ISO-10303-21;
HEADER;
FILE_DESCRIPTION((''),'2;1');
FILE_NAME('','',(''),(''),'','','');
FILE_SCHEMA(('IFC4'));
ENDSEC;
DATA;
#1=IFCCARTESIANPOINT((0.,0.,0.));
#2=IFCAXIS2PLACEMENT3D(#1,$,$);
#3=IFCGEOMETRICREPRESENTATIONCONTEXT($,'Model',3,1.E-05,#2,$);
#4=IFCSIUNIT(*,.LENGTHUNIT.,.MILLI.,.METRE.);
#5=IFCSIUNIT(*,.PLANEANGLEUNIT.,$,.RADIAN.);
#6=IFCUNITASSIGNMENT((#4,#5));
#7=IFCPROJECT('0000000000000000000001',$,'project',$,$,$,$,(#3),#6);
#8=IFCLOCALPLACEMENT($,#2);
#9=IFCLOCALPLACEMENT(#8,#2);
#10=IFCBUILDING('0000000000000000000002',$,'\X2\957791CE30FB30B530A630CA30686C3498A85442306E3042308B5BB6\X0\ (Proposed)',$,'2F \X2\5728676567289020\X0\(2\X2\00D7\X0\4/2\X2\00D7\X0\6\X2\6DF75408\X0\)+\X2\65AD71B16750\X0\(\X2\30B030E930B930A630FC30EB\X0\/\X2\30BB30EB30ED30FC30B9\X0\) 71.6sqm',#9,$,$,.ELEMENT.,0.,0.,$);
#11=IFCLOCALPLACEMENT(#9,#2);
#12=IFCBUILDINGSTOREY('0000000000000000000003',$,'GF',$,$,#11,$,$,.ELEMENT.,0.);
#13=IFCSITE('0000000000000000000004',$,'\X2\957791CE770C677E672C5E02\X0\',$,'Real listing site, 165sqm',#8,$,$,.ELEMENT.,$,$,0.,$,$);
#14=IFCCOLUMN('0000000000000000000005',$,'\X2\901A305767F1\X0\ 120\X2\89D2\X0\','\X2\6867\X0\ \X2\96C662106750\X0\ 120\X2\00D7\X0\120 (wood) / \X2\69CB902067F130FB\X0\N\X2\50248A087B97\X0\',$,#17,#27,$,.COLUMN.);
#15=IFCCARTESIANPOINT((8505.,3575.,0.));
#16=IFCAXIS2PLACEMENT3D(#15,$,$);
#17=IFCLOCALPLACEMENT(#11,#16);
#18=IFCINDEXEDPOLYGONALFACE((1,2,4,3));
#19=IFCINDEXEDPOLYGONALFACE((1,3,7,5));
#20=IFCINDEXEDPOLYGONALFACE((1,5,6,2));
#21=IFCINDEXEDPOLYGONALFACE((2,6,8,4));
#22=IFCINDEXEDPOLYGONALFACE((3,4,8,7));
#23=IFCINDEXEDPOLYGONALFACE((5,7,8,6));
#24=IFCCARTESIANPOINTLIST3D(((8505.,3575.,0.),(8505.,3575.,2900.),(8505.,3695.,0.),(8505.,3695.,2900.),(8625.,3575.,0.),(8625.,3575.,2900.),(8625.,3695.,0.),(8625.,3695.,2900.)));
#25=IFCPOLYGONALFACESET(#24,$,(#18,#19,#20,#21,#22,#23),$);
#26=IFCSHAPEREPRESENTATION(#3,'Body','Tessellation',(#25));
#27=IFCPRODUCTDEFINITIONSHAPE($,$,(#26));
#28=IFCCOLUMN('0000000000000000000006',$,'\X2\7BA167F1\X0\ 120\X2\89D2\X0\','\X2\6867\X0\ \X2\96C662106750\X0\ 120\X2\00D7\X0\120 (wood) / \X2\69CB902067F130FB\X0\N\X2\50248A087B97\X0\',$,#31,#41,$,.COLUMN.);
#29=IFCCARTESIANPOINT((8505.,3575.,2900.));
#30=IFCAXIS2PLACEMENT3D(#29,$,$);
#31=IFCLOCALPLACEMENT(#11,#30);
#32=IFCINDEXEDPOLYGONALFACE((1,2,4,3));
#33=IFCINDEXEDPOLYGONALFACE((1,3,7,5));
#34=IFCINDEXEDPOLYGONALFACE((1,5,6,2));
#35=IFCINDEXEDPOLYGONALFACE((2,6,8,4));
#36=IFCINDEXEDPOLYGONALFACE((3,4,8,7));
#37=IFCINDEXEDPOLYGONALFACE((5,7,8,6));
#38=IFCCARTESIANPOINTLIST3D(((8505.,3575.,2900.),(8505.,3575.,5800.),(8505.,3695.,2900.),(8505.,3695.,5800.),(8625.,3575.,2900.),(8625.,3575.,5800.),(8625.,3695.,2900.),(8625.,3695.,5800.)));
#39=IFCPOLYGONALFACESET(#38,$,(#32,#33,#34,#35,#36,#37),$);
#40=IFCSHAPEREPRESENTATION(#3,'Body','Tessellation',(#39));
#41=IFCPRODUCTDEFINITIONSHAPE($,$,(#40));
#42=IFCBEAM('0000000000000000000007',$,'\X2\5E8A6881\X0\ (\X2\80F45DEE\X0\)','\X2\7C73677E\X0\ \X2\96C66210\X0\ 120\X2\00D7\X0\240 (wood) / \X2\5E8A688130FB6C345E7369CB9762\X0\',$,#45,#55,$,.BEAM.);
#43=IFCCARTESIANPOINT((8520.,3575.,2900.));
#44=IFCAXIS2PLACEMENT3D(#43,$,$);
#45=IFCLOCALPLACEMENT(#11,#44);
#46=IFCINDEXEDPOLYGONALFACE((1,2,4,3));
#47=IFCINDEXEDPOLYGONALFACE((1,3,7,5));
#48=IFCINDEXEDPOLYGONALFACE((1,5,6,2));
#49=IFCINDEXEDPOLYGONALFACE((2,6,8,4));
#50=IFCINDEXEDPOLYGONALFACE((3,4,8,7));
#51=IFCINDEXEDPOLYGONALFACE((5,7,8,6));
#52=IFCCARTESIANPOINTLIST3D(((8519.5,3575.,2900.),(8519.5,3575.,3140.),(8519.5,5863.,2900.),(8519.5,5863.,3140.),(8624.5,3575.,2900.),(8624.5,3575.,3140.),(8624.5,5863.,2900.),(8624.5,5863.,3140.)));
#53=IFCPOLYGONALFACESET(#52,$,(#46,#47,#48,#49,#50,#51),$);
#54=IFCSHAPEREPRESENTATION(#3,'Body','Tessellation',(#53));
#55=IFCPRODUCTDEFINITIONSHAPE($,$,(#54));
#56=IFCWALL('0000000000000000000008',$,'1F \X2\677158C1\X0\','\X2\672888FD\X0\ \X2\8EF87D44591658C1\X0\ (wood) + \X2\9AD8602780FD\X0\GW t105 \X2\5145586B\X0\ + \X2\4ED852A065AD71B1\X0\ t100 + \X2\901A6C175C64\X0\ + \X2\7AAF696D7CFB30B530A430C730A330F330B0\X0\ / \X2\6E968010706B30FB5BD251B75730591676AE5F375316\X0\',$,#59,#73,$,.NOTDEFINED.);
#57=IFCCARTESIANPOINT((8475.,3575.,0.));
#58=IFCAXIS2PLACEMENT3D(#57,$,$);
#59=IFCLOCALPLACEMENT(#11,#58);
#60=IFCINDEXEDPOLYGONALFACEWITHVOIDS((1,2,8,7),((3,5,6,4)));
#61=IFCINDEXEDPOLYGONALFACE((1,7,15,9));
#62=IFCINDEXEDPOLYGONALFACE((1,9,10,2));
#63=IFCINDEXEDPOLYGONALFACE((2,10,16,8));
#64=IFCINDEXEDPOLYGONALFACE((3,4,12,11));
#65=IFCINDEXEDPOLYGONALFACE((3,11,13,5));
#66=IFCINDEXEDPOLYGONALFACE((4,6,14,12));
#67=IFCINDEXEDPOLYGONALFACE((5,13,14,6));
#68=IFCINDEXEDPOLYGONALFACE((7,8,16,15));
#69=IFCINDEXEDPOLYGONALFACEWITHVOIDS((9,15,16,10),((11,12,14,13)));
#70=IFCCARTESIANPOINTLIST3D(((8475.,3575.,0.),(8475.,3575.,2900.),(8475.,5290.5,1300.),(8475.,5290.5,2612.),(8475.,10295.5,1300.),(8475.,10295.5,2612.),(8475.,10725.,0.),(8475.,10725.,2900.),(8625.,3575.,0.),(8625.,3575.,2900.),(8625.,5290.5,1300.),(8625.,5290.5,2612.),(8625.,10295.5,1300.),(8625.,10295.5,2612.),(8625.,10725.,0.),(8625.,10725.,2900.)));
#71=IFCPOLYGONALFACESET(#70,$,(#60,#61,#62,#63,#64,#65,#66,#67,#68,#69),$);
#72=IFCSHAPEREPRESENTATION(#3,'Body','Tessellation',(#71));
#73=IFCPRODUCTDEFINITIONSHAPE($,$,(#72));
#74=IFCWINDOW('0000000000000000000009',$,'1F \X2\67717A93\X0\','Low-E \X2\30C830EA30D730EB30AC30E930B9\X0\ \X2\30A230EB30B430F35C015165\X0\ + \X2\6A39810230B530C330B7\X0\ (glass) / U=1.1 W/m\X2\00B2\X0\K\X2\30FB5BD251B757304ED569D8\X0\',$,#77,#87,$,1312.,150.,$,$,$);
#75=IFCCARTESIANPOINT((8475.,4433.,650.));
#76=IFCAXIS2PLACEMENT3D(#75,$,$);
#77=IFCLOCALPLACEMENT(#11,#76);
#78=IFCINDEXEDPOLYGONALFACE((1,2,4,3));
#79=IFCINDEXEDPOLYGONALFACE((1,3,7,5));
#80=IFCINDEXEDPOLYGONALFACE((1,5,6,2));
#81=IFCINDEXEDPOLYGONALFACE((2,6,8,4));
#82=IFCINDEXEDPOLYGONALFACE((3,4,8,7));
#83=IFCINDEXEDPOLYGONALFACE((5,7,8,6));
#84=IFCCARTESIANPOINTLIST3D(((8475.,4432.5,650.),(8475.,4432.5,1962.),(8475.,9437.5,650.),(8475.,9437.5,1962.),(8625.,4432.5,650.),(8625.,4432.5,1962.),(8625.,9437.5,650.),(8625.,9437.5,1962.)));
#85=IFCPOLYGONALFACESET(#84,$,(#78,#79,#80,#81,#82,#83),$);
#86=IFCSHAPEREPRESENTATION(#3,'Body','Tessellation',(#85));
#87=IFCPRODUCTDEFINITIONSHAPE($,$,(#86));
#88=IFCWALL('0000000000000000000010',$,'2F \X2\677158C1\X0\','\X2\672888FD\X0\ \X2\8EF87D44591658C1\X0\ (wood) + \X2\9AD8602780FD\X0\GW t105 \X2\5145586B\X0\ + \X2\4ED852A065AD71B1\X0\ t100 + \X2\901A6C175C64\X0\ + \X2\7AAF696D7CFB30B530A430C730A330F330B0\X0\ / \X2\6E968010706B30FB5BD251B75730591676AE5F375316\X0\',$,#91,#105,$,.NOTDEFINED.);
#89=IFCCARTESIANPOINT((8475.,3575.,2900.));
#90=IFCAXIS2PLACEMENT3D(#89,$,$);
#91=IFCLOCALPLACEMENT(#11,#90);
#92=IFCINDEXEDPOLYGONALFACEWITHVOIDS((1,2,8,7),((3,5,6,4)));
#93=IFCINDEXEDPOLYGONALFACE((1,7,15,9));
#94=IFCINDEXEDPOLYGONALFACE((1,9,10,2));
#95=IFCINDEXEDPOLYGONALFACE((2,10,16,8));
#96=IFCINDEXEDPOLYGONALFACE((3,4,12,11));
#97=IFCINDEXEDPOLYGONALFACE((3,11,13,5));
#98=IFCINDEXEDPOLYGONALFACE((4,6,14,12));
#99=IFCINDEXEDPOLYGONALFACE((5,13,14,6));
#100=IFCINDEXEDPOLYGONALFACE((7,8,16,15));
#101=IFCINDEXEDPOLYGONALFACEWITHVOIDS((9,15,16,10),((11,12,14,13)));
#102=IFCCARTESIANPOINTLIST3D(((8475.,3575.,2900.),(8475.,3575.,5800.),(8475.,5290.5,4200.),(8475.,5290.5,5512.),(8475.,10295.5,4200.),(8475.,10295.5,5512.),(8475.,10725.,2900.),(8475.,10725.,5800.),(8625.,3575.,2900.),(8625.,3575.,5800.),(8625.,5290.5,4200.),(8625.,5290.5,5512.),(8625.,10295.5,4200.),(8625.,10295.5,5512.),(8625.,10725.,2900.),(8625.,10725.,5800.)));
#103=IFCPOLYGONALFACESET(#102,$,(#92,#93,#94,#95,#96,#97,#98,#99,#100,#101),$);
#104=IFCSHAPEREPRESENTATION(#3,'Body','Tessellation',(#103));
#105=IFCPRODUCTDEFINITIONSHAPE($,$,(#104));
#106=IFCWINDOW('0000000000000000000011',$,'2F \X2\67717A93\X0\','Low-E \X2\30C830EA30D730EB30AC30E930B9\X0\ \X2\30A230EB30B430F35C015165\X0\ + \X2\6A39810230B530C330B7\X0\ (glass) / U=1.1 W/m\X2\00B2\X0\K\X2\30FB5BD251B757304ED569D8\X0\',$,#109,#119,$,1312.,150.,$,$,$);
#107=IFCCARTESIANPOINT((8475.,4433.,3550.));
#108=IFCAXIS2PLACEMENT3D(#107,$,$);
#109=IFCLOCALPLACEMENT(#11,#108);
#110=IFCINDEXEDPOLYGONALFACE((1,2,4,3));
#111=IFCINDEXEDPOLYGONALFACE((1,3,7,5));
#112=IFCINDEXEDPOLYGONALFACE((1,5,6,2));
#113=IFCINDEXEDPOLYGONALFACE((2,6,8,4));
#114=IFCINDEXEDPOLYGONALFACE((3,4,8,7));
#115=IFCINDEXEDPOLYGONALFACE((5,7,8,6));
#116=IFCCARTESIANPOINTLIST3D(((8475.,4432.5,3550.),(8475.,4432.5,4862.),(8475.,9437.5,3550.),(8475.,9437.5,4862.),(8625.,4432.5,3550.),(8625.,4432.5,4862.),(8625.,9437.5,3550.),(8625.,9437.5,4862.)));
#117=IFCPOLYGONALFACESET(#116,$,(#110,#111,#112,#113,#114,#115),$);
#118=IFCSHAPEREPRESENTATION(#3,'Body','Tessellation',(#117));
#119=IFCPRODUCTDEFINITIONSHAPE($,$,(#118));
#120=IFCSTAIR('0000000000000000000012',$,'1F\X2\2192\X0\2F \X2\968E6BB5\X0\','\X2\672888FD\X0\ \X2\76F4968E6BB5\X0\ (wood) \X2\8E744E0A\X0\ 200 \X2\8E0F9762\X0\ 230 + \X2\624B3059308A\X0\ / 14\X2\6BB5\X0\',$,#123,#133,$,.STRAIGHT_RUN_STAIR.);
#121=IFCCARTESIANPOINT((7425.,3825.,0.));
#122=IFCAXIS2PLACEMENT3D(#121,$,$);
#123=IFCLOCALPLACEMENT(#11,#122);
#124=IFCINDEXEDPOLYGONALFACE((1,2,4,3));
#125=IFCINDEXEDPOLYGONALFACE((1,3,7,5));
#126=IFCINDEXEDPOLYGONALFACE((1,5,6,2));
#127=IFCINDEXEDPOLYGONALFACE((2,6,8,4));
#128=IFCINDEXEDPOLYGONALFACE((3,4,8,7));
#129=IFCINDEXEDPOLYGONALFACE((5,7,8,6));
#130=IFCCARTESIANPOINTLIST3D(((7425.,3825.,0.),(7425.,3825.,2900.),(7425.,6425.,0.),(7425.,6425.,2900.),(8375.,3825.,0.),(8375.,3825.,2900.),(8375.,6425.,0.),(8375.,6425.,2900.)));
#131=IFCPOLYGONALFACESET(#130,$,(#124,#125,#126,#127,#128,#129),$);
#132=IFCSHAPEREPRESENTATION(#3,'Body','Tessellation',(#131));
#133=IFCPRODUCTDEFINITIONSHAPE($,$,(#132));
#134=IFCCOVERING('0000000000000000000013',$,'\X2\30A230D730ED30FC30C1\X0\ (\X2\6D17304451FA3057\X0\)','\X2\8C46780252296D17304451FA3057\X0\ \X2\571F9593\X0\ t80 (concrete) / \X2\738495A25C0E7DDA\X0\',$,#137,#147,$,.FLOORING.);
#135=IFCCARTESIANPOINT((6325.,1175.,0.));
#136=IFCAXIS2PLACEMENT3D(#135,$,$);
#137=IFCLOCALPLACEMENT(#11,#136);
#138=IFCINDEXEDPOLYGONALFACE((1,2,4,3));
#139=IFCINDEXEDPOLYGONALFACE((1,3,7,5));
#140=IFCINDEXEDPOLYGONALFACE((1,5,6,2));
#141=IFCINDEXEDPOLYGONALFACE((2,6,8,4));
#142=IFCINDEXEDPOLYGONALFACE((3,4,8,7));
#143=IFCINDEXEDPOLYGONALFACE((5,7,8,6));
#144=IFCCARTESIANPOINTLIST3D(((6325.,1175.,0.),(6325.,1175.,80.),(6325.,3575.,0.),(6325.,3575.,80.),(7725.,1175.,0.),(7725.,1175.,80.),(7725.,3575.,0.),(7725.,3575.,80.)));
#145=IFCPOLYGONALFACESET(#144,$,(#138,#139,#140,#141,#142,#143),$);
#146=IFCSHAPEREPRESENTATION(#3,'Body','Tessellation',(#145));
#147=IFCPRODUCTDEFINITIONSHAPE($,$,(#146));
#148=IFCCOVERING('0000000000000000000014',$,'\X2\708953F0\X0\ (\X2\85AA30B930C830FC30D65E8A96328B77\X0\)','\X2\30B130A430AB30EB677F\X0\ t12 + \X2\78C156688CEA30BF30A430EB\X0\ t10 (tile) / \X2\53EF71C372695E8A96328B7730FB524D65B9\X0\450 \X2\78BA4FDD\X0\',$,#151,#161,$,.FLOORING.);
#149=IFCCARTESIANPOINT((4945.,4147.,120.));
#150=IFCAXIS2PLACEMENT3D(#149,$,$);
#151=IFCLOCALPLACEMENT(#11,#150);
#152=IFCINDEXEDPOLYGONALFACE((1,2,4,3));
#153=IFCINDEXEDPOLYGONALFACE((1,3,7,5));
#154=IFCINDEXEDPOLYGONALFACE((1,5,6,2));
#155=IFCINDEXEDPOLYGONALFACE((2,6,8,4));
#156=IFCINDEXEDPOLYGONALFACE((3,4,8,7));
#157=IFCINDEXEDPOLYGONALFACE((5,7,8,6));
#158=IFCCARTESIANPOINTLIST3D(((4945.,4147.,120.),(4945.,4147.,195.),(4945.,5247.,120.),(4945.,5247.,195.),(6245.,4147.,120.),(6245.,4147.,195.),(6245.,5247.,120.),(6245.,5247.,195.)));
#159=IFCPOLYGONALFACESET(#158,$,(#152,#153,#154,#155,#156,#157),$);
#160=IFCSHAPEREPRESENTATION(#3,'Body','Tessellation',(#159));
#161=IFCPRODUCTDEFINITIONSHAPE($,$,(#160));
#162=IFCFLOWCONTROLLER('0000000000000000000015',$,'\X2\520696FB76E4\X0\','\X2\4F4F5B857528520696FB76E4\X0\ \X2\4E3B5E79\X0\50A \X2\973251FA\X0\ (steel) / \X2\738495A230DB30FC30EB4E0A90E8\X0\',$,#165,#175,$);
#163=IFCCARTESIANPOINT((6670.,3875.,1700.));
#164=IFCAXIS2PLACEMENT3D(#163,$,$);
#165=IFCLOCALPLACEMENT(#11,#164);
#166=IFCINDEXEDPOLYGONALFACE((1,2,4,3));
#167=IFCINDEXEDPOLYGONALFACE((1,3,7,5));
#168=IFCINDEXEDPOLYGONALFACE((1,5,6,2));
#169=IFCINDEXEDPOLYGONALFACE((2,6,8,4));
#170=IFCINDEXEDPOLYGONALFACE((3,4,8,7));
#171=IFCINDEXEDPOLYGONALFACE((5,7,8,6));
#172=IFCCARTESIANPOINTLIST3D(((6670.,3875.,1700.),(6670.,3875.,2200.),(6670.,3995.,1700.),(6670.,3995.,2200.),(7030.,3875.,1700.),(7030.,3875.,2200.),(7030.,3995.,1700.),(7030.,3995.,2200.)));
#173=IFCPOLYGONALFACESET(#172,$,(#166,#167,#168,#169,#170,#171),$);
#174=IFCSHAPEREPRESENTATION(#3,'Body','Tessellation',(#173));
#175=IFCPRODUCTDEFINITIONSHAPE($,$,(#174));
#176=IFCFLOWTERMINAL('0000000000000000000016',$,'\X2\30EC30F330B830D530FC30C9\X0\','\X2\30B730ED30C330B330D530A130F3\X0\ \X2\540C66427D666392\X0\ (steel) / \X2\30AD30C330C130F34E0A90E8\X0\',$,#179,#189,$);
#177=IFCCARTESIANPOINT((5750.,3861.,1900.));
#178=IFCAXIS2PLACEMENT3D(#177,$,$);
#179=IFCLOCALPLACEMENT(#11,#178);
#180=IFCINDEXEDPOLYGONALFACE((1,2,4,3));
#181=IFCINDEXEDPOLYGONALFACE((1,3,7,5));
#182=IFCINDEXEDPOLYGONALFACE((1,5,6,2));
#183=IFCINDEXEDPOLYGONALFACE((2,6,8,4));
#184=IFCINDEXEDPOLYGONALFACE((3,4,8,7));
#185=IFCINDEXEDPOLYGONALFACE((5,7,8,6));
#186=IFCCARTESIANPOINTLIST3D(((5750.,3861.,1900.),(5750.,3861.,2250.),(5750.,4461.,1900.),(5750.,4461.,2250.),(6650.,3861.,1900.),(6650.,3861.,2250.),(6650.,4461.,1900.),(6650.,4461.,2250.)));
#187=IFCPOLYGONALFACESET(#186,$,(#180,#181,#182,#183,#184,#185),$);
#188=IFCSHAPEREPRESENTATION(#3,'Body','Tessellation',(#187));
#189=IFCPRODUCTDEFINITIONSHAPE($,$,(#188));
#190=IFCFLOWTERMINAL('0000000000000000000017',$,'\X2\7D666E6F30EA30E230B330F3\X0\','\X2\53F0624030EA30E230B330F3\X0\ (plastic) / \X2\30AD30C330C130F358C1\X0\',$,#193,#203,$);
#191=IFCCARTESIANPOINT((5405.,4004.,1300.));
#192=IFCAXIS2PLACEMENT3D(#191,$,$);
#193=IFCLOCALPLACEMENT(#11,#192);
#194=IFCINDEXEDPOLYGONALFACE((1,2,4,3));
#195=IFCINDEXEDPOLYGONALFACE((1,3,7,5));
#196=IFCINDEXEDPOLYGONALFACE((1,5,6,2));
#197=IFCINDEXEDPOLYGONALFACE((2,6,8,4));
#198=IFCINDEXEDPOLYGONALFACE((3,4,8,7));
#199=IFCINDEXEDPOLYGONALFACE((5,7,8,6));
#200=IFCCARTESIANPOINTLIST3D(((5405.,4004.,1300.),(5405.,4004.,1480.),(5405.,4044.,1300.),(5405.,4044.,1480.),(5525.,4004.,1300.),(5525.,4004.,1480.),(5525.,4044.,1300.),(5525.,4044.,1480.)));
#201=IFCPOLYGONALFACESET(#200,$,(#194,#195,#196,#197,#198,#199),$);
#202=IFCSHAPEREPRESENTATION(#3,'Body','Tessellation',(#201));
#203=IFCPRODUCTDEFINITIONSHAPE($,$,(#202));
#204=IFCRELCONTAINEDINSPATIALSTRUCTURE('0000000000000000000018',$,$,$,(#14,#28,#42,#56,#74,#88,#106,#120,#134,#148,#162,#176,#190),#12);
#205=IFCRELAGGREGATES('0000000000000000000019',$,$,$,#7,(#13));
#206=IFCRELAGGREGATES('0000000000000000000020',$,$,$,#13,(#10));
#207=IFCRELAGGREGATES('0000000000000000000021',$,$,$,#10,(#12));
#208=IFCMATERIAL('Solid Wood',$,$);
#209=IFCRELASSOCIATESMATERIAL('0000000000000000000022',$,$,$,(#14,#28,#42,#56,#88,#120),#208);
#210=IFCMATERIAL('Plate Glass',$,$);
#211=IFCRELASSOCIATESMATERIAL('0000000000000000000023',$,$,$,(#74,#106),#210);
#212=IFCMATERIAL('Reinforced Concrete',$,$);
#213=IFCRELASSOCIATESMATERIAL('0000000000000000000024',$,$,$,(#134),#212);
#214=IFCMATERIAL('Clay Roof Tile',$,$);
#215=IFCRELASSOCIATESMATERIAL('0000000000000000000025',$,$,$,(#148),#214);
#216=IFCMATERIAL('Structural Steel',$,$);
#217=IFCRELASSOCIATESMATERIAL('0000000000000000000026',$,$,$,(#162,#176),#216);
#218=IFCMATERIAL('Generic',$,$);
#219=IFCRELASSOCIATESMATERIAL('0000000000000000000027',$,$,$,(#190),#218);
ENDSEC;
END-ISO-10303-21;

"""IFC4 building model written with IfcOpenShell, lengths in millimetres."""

from ifc_helpers import new_model, si_unit, frame, frame_2d, origin, place, context, project, spatial, rectangle, extrude, material, element, fill, save


model = new_model("IFC4")

# Units and contexts
model_context = context("Model", 3, precision=1e-05, world=origin())
ifc_project = project(units=[si_unit("LENGTHUNIT", "METRE", prefix="MILLI"), si_unit("PLANEANGLEUNIT", "RADIAN")], contexts=[model_context])

# Site, building, storey
site_placement = place(None, origin())
site = spatial("IfcSite", under=ifc_project, at=site_placement, Name="長野県松本市", ObjectType="Real listing site, 165sqm", CompositionType="ELEMENT", RefElevation=0.0)
building_placement = place(site_placement, origin())
building = spatial("IfcBuilding", under=site, at=building_placement, Name="長野・サウナと水風呂のある家 (Proposed)", ObjectType="2F 在来木造(2×4/2×6混合)+断熱材(グラスウール/セルロース) 71.6sqm", CompositionType="ELEMENT", ElevationOfRefHeight=0.0, ElevationOfTerrain=0.0)
storey_placement = place(building_placement, origin())
storey = spatial("IfcBuildingStorey", under=building, at=storey_placement, Name="GF", CompositionType="ELEMENT", Elevation=0.0)

# Columns
ifc_material_1 = material(Name="Solid Wood")
column_1_placement = place(storey_placement, frame((8505.0, 3575.0, 0.0)))
element("IfcColumn", 1, at=column_1_placement, inside=storey, material=ifc_material_1, Name="通し柱 120角", Description="桧 集成材 120×120 (wood) / 構造柱・N値計算", PredefinedType="COLUMN", context=model_context, shape_type="SweptSolid", body=[
    extrude(rectangle(XDim=120.0, YDim=120.0, at=frame_2d((60.0, 60.0))), frame((8505.0, 3575.0, 0.0)), (0.0, 0.0, 1.0), 2900.0),
])
column_2_placement = place(storey_placement, frame((8505.0, 3575.0, 2900.0)))
element("IfcColumn", 2, at=column_2_placement, inside=storey, material=ifc_material_1, Name="管柱 120角", Description="桧 集成材 120×120 (wood) / 構造柱・N値計算", PredefinedType="COLUMN", context=model_context, shape_type="SweptSolid", body=[
    extrude(rectangle(XDim=120.0, YDim=120.0, at=frame_2d((60.0, 60.0))), frame((8505.0, 3575.0, 2900.0)), (0.0, 0.0, 1.0), 2900.0),
])

# Beam
beam_1_placement = place(storey_placement, frame((8520.0, 3575.0, 2900.0)))
element("IfcBeam", 3, at=beam_1_placement, inside=storey, material=ifc_material_1, Name="床梁 (胴差)", Description="米松 集成 120×240 (wood) / 床梁・水平構面", PredefinedType="BEAM", context=model_context, shape_type="SweptSolid", body=[
    extrude(rectangle(XDim=105.0, YDim=2288.0, at=frame_2d((52.0, 1144.0))), frame((8520.0, 3575.0, 2900.0)), (0.0, 0.0, 1.0), 240.0),
])

# Wall, opening, window
wall_1_placement = place(storey_placement, frame((8475.0, 3575.0, 0.0)))
wall_1 = element("IfcWall", 4, at=wall_1_placement, inside=storey, material=ifc_material_1, Name="1F 東壁", Description="木製 軸組外壁 (wood) + 高性能GW t105 充填 + 付加断熱 t100 + 通気層 + 窯業系サイディング / 準耐火・寒冷地外皮強化", PredefinedType="NOTDEFINED", context=model_context, shape_type="SweptSolid", body=[
    extrude(rectangle(XDim=150.0, YDim=7150.0, at=frame_2d((75.0, 3575.0))), frame((8475.0, 3575.0, 0.0)), (0.0, 0.0, 1.0), 2900.0),
])
opening_1_placement = place(storey_placement, frame((8475.0, 4433.0, 650.0)))
opening_1 = element("IfcOpeningElement", 5, at=opening_1_placement, cuts=wall_1, PredefinedType="NOTDEFINED", context=model_context, shape_type="SweptSolid", body=[
    extrude(rectangle(XDim=150.0, YDim=5005.0, at=frame_2d((75.0, 2502.0))), frame((8475.0, 4433.0, 650.0)), (0.0, 0.0, 1.0), 1312.0),
])
ifc_material_2 = material(Name="Plate Glass")
window_1_placement = place(storey_placement, frame((8475.0, 4433.0, 650.0)))
window_1 = element("IfcWindow", 6, at=window_1_placement, inside=storey, material=ifc_material_2, Name="1F 東窓", Description="Low-E トリプルガラス アルゴン封入 + 樹脂サッシ (glass) / U=1.1 W/m²K・寒冷地仕様", OverallHeight=1312.0, OverallWidth=150.0, context=model_context, shape_type="SweptSolid", body=[
    extrude(rectangle(XDim=150.0, YDim=5005.0, at=frame_2d((75.0, 2502.0))), frame((8475.0, 4433.0, 650.0)), (0.0, 0.0, 1.0), 1312.0),
])
fill(opening_1, window_1)

# Wall, opening, window
wall_2_placement = place(storey_placement, frame((8475.0, 3575.0, 2900.0)))
wall_2 = element("IfcWall", 7, at=wall_2_placement, inside=storey, material=ifc_material_1, Name="2F 東壁", Description="木製 軸組外壁 (wood) + 高性能GW t105 充填 + 付加断熱 t100 + 通気層 + 窯業系サイディング / 準耐火・寒冷地外皮強化", PredefinedType="NOTDEFINED", context=model_context, shape_type="SweptSolid", body=[
    extrude(rectangle(XDim=150.0, YDim=7150.0, at=frame_2d((75.0, 3575.0))), frame((8475.0, 3575.0, 2900.0)), (0.0, 0.0, 1.0), 2900.0),
])
opening_2_placement = place(storey_placement, frame((8475.0, 4433.0, 3550.0)))
opening_2 = element("IfcOpeningElement", 8, at=opening_2_placement, cuts=wall_2, PredefinedType="NOTDEFINED", context=model_context, shape_type="SweptSolid", body=[
    extrude(rectangle(XDim=150.0, YDim=5005.0, at=frame_2d((75.0, 2502.0))), frame((8475.0, 4433.0, 3550.0)), (0.0, 0.0, 1.0), 1312.0),
])
window_2_placement = place(storey_placement, frame((8475.0, 4433.0, 3550.0)))
window_2 = element("IfcWindow", 9, at=window_2_placement, inside=storey, material=ifc_material_2, Name="2F 東窓", Description="Low-E トリプルガラス アルゴン封入 + 樹脂サッシ (glass) / U=1.1 W/m²K・寒冷地仕様", OverallHeight=1312.0, OverallWidth=150.0, context=model_context, shape_type="SweptSolid", body=[
    extrude(rectangle(XDim=150.0, YDim=5005.0, at=frame_2d((75.0, 2502.0))), frame((8475.0, 4433.0, 3550.0)), (0.0, 0.0, 1.0), 1312.0),
])
fill(opening_2, window_2)

# Stair
stair_placement = place(storey_placement, frame((7425.0, 3825.0, 0.0)))
element("IfcStair", 10, at=stair_placement, inside=storey, material=ifc_material_1, Name="1F→2F 階段", Description="木製 直階段 (wood) 蹴上 200 踏面 230 + 手すり / 14段", PredefinedType="STRAIGHT_RUN_STAIR", context=model_context, shape_type="SweptSolid", body=[
    extrude(rectangle(XDim=950.0, YDim=2600.0, at=frame_2d((475.0, 1300.0))), frame((7425.0, 3825.0, 0.0)), (0.0, 0.0, 1.0), 2900.0),
])

# Coverings
ifc_material_3 = material(Name="Reinforced Concrete")
covering_1_placement = place(storey_placement, frame((6325.0, 1175.0, 0.0)))
element("IfcCovering", 11, at=covering_1_placement, inside=storey, material=ifc_material_3, Name="アプローチ (洗い出し)", Description="豆砂利洗い出し 土間 t80 (concrete) / 玄関導線", PredefinedType="FLOORING", context=model_context, shape_type="SweptSolid", body=[
    extrude(rectangle(XDim=1400.0, YDim=2400.0, at=frame_2d((700.0, 1200.0))), frame((6325.0, 1175.0, 0.0)), (0.0, 0.0, 1.0), 80.0),
])
ifc_material_4 = material(Name="Clay Roof Tile")
covering_2_placement = place(storey_placement, frame((4945.0, 4147.0, 120.0)))
element("IfcCovering", 12, at=covering_2_placement, inside=storey, material=ifc_material_4, Name="炉台 (薪ストーブ床防護)", Description="ケイカル板 t12 + 磁器質タイル t10 (tile) / 可燃物床防護・前方450 確保", PredefinedType="FLOORING", context=model_context, shape_type="SweptSolid", body=[
    extrude(rectangle(XDim=1300.0, YDim=1100.0, at=frame_2d((650.0, 550.0))), frame((4945.0, 4147.0, 120.0)), (0.0, 0.0, 1.0), 75.0),
])

# Flow controller
ifc_material_5 = material(Name="Structural Steel")
flow_controller_placement = place(storey_placement, frame((6670.0, 3875.0, 1700.0)))
element("IfcFlowController", 13, at=flow_controller_placement, inside=storey, material=ifc_material_5, Name="分電盤", Description="住宅用分電盤 主幹50A 露出 (steel) / 玄関ホール上部", context=model_context, shape_type="SweptSolid", body=[
    extrude(rectangle(XDim=360.0, YDim=120.0, at=frame_2d((180.0, 60.0))), frame((6670.0, 3875.0, 1700.0)), (0.0, 0.0, 1.0), 500.0),
])

# Flow terminals
flow_terminal_1_placement = place(storey_placement, frame((5750.0, 3861.0, 1900.0)))
element("IfcFlowTerminal", 14, at=flow_terminal_1_placement, inside=storey, material=ifc_material_5, Name="レンジフード", Description="シロッコファン 同時給排 (steel) / キッチン上部", context=model_context, shape_type="SweptSolid", body=[
    extrude(rectangle(XDim=900.0, YDim=600.0, at=frame_2d((450.0, 300.0))), frame((5750.0, 3861.0, 1900.0)), (0.0, 0.0, 1.0), 350.0),
])
ifc_material_6 = material(Name="Generic")
flow_terminal_2_placement = place(storey_placement, frame((5405.0, 4004.0, 1300.0)))
element("IfcFlowTerminal", 15, at=flow_terminal_2_placement, inside=storey, material=ifc_material_6, Name="給湯リモコン", Description="台所リモコン (plastic) / キッチン壁", context=model_context, shape_type="SweptSolid", body=[
    extrude(rectangle(XDim=120.0, YDim=40.0, at=frame_2d((60.0, 20.0))), frame((5405.0, 4004.0, 1300.0)), (0.0, 0.0, 1.0), 180.0),
])

save(model, "model.ifc")
